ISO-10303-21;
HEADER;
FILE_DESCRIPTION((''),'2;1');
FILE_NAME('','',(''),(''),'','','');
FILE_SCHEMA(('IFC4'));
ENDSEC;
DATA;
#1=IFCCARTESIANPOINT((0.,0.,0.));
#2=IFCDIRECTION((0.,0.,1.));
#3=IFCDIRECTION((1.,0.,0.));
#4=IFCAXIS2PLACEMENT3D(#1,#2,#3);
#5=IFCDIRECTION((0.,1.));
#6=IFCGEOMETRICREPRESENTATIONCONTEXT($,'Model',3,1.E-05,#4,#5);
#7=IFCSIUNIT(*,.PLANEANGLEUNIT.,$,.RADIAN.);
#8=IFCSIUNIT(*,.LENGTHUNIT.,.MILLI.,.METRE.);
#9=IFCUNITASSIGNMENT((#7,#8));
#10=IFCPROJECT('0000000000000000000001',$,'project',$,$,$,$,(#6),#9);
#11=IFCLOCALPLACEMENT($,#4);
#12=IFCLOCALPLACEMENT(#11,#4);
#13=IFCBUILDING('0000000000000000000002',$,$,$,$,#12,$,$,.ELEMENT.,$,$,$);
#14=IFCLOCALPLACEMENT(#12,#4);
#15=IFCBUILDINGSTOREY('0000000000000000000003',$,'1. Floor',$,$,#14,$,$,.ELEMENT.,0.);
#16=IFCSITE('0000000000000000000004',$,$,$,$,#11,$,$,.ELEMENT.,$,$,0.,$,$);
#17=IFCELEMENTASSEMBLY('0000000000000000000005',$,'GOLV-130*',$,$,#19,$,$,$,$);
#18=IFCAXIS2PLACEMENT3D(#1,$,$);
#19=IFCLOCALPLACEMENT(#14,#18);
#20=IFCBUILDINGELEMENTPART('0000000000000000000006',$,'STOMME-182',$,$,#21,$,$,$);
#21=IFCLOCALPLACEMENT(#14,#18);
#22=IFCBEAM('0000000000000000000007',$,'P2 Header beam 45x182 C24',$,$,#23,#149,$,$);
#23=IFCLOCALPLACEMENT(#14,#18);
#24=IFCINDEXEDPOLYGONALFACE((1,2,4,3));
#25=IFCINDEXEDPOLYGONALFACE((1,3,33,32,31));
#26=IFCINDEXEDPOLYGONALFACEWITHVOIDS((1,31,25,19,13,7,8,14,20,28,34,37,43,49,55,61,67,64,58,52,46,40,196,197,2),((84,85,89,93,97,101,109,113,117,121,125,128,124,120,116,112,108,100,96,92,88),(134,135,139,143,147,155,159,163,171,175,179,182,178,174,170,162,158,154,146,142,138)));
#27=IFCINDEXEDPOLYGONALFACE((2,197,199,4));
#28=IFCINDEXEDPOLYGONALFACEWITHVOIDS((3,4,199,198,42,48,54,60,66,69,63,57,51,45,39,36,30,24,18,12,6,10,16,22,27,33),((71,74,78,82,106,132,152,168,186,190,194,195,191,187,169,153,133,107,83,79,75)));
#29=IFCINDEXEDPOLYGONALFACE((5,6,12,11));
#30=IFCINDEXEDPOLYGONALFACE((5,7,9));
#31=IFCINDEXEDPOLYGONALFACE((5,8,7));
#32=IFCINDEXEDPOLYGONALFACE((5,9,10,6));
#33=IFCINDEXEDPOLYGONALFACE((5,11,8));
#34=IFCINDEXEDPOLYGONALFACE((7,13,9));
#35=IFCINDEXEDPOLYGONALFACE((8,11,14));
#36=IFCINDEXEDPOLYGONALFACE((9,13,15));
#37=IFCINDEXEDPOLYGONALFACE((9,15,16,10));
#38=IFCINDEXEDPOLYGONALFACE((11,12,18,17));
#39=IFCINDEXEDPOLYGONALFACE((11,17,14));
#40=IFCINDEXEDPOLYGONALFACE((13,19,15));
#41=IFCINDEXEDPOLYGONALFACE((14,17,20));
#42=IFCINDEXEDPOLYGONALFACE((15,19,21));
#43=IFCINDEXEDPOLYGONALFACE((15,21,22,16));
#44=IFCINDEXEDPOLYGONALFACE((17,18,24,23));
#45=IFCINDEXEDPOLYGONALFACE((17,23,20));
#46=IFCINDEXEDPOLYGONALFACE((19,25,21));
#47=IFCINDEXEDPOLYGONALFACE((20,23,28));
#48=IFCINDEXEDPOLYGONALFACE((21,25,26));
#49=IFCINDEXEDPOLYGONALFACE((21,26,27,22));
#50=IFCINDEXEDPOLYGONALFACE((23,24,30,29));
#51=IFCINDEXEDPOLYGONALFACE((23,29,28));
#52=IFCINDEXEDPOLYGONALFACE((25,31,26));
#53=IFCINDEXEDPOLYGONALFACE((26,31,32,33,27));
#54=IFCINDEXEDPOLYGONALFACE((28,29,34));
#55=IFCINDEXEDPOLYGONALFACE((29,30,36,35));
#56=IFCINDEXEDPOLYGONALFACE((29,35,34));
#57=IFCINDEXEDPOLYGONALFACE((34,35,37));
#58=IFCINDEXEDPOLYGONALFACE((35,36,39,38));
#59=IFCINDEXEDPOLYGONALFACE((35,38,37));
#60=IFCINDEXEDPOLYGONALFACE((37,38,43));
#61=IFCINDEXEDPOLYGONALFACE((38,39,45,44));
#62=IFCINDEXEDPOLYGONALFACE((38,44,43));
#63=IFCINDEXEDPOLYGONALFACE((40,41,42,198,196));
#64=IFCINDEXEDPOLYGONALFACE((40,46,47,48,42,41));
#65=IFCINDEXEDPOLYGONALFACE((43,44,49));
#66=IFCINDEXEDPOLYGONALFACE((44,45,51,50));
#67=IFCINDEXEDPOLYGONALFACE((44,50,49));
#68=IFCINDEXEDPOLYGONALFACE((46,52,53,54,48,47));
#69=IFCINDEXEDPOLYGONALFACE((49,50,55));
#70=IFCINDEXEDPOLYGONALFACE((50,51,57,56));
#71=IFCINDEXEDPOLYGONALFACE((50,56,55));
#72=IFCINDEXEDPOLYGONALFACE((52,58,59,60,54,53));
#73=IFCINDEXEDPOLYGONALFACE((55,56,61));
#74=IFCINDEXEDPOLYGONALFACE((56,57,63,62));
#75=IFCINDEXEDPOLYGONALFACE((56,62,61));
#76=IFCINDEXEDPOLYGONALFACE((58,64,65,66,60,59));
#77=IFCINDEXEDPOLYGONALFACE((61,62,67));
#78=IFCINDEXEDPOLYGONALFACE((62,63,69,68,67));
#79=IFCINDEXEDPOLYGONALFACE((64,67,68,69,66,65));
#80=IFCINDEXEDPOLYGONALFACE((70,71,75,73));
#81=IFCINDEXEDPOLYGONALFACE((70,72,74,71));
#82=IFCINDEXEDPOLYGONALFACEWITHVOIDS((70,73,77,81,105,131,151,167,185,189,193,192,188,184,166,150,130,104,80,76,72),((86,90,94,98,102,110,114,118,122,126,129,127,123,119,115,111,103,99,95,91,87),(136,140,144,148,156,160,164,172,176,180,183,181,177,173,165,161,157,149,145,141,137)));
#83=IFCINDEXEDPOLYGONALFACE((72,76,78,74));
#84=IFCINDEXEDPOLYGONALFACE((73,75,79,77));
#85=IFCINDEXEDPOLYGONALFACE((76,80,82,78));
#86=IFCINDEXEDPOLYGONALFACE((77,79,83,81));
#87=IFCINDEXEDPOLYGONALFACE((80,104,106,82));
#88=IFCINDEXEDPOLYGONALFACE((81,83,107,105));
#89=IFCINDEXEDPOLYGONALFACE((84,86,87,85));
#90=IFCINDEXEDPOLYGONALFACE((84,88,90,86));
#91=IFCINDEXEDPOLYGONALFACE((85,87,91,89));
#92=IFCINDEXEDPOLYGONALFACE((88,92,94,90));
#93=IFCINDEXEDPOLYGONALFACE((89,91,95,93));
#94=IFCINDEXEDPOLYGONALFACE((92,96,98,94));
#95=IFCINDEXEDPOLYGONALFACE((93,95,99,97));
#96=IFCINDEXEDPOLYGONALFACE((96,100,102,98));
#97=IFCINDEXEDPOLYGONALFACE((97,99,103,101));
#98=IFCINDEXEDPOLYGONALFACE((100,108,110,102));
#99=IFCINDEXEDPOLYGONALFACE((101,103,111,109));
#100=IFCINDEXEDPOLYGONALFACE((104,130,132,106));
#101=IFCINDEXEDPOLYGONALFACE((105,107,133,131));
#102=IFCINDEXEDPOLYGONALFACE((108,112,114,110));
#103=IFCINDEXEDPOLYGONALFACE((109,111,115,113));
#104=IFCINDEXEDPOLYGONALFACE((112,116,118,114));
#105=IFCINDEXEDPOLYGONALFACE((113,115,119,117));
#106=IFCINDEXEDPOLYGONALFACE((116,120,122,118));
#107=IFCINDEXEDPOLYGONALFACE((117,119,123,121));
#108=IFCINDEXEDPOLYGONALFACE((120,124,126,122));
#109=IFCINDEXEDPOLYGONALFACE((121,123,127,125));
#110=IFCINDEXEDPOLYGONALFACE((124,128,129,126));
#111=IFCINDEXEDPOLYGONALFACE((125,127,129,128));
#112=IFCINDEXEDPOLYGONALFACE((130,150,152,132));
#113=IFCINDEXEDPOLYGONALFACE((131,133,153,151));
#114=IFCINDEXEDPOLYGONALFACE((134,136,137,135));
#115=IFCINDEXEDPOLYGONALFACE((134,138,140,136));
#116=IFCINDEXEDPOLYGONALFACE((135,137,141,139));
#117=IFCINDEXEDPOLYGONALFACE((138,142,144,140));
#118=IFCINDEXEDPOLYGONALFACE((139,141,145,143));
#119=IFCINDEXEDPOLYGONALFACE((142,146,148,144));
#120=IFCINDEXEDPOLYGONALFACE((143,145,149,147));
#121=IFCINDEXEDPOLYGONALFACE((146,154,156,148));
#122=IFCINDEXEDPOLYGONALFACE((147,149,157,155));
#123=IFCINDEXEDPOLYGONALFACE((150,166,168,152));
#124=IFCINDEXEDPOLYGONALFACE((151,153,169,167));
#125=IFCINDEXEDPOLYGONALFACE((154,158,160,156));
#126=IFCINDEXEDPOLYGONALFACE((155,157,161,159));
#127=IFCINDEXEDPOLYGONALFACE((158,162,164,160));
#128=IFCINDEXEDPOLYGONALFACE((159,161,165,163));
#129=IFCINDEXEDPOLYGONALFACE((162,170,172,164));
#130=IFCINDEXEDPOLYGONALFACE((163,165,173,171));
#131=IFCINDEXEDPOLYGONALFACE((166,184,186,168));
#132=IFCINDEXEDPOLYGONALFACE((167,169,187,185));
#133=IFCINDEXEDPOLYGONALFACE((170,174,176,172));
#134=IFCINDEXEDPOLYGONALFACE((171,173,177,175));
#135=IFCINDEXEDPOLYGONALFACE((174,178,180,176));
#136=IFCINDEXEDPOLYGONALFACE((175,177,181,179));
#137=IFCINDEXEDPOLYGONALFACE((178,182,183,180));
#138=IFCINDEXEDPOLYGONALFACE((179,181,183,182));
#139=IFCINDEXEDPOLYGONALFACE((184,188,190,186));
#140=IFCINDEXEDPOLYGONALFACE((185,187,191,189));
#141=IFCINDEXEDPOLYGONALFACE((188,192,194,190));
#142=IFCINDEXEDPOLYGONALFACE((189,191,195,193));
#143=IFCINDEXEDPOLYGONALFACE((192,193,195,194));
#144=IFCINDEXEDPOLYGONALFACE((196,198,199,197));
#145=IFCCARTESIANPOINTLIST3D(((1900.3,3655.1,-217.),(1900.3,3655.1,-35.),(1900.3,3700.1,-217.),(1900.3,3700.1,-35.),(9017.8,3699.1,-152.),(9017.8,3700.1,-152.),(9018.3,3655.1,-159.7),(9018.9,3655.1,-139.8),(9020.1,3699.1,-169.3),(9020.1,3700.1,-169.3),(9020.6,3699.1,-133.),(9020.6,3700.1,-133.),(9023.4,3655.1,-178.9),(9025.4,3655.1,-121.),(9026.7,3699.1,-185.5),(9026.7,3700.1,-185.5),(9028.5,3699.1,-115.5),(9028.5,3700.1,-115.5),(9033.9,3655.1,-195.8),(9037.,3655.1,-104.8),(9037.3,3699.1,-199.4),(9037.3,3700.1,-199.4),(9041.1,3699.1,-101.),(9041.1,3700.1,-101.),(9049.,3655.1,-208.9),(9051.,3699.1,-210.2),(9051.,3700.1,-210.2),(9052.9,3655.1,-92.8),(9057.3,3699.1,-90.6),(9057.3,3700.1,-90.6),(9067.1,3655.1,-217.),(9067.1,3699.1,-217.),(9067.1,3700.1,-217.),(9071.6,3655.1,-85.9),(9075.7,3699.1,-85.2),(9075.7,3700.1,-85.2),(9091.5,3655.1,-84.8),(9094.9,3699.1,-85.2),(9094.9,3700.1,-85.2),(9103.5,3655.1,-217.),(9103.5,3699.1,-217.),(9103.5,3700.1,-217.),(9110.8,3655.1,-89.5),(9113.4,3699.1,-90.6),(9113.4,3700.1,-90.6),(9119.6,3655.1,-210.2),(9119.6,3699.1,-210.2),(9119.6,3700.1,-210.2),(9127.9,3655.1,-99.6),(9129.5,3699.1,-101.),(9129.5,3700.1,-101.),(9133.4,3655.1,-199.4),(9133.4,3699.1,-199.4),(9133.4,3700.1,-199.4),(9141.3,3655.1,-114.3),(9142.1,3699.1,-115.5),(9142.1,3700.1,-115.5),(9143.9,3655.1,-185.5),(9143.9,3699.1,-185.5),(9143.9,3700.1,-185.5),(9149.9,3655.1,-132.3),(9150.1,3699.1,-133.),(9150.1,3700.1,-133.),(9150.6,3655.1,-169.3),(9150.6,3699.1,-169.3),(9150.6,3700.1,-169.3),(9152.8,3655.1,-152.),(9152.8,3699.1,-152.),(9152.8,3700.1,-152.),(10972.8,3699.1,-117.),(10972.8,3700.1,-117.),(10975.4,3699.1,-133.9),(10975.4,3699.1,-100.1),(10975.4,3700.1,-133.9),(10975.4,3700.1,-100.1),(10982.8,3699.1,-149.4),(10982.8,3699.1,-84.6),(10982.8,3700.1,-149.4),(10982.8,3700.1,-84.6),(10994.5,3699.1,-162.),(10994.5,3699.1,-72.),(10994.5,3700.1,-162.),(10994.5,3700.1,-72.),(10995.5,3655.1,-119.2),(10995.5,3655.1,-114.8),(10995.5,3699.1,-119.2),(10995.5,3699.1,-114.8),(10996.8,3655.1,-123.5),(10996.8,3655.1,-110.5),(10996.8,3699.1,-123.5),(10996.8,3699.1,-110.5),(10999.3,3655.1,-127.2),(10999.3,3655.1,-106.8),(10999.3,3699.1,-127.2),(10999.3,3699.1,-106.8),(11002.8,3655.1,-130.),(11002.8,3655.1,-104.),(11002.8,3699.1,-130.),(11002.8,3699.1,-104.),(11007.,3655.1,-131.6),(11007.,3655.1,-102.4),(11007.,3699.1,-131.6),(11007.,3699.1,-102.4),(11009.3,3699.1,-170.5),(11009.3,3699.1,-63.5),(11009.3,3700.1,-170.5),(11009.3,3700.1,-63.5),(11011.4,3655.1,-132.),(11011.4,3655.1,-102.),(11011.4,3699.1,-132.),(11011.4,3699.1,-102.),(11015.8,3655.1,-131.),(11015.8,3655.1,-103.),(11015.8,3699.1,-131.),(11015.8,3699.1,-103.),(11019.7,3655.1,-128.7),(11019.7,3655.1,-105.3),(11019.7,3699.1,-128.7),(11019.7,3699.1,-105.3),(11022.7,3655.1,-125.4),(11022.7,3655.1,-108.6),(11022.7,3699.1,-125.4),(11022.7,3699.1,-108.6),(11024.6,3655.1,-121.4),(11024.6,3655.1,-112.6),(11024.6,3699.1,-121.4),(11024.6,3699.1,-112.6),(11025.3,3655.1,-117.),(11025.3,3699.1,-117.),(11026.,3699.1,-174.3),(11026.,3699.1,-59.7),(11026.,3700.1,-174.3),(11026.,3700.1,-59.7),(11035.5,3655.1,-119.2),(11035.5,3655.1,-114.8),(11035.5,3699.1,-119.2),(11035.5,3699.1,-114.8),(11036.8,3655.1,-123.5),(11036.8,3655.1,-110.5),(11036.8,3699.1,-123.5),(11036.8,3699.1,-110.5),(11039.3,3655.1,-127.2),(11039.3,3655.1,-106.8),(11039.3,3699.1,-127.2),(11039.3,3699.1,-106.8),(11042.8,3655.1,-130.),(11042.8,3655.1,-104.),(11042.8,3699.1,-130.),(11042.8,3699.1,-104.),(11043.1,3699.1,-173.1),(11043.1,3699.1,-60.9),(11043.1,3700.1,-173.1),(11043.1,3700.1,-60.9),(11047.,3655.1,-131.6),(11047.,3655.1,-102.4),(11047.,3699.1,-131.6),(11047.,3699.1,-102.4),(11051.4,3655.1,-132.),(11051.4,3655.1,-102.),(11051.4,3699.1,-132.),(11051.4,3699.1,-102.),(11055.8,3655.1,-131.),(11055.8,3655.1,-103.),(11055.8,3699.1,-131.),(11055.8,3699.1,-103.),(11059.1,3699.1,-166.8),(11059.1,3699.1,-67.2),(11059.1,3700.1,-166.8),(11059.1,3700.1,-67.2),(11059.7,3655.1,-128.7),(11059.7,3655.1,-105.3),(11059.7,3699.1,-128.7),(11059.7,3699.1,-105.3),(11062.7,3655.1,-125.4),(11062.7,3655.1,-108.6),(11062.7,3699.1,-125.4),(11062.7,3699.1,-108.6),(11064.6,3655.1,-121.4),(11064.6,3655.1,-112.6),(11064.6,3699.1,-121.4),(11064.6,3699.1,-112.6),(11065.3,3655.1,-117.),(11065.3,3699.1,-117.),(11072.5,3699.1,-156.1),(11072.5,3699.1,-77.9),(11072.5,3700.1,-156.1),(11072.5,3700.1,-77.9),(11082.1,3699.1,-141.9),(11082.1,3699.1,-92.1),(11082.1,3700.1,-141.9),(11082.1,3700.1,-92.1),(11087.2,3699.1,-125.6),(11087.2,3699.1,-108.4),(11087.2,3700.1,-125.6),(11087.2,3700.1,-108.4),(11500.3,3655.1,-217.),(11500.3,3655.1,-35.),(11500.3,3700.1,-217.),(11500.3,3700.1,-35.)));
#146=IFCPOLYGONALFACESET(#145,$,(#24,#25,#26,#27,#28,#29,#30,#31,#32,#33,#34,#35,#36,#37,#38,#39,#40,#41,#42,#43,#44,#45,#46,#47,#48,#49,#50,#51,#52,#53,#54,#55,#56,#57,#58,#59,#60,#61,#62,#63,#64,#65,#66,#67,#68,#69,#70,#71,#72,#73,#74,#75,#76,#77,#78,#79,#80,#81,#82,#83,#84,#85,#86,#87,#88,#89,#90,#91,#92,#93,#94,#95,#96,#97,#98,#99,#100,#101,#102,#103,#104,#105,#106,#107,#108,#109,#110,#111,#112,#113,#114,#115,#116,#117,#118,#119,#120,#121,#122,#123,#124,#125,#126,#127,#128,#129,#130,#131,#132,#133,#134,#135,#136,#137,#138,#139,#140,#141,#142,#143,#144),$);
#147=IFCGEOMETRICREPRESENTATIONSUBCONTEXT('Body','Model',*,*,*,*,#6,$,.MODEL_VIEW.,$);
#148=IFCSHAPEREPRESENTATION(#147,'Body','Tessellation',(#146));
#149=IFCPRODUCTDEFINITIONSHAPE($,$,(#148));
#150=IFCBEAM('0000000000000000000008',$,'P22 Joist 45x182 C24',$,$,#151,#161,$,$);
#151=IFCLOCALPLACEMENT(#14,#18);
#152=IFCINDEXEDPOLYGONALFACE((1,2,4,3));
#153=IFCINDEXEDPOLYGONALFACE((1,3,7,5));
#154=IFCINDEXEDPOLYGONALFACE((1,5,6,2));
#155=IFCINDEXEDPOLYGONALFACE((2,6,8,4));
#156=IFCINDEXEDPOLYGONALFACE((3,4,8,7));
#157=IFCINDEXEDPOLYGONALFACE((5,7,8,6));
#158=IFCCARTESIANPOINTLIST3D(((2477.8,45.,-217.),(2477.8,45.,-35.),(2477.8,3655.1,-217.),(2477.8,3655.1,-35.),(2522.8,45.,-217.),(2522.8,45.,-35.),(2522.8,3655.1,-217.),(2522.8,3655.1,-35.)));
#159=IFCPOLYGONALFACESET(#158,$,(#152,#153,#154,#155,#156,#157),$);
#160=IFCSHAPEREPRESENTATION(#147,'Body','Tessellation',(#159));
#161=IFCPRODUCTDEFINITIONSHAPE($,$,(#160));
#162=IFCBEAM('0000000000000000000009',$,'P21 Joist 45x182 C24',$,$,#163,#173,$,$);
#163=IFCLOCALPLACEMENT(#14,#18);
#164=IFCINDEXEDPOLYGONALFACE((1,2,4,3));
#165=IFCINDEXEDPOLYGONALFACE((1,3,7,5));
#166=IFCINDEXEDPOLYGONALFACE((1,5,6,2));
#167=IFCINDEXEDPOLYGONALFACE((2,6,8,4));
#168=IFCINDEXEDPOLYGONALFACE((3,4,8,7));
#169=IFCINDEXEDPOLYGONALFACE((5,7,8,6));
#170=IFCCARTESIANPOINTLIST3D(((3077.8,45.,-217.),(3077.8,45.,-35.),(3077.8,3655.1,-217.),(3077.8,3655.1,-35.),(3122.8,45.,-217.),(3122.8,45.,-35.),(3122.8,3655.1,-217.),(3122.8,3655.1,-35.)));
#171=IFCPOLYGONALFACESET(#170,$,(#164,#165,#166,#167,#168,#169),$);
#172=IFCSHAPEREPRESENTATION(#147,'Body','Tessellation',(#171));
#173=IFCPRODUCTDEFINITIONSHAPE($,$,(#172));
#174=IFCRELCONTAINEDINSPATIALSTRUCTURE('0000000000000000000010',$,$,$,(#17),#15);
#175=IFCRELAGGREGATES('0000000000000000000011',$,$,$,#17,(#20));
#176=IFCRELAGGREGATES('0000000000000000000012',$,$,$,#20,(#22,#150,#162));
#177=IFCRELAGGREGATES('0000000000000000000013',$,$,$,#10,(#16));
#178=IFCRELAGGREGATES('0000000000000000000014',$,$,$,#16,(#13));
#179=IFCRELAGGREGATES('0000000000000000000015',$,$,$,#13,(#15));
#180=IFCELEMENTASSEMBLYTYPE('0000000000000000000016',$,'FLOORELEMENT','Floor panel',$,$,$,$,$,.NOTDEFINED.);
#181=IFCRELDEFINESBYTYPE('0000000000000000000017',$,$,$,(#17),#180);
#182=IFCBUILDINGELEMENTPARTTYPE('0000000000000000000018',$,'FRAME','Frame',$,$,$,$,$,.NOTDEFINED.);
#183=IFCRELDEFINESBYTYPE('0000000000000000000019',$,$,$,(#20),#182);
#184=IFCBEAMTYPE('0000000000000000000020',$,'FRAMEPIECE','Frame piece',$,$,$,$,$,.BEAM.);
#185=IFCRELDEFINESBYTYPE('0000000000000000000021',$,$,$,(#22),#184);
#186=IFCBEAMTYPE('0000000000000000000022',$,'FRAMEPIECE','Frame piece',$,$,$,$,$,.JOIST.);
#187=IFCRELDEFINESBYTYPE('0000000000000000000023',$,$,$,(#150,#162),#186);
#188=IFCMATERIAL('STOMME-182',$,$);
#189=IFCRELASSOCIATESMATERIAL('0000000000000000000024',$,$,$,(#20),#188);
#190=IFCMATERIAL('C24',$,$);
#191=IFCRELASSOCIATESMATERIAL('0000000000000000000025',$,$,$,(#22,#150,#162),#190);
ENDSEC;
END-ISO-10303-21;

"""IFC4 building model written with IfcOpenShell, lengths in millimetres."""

from ifc_helpers import new_model, si_unit, direction, frame, origin_with_axes, origin_2d_with_axis, place, context, subcontext, project, spatial, rectangle, circle, extrude, boolean, material, type_object, element, aggregate, save


model = new_model("IFC4")

# Units and contexts
model_context = context("Model", 3, precision=1e-05, world=origin_with_axes(), true_north=direction((0.0, 1.0)))
body_context = subcontext(model_context, "Body", "Model", "MODEL_VIEW")
ifc_project = project(units=[si_unit("PLANEANGLEUNIT", "RADIAN"), si_unit("LENGTHUNIT", "METRE", prefix="MILLI")], contexts=[model_context])

# Site, building, storey
site_placement = place(None, origin_with_axes())
site = spatial("IfcSite", under=ifc_project, at=site_placement, CompositionType="ELEMENT", RefElevation=0.0)
building_placement = place(site_placement, origin_with_axes())
building = spatial("IfcBuilding", under=site, at=building_placement, CompositionType="ELEMENT")
storey_placement = place(building_placement, origin_with_axes())
storey = spatial("IfcBuildingStorey", under=building, at=storey_placement, Name="1. Floor", CompositionType="ELEMENT", Elevation=0.0)

# Element assembly, building element part, beams
element_assembly_type = type_object("IfcElementAssemblyType", Name="FLOORELEMENT", Description="Floor panel", PredefinedType="NOTDEFINED")
assembly_placement = place(storey_placement, origin_with_axes())
assembly = element("IfcElementAssembly", 1, at=assembly_placement, inside=storey, type_object=element_assembly_type, Name="GOLV-130*")
ifc_material_1 = material(Name="STOMME-182")
building_element_part_type = type_object("IfcBuildingElementPartType", Name="FRAME", Description="Frame", PredefinedType="NOTDEFINED")
building_element_part_placement = place(storey_placement, origin_with_axes())
building_element_part = element("IfcBuildingElementPart", 2, at=building_element_part_placement, type_object=building_element_part_type, material=ifc_material_1, Name="STOMME-182")
aggregate(assembly, [building_element_part])
ifc_material_2 = material(Name="C24")
beam_type_1 = type_object("IfcBeamType", Name="FRAMEPIECE", Description="Frame piece", PredefinedType="BEAM")
beam_1_placement = place(storey_placement, frame((1900.3, 3677.6, -126.0), z_axis=(1.0, 0.0, 0.0), x_axis=(0.0, 1.0, 0.0)))
solid_1 = boolean("DIFFERENCE", boolean("DIFFERENCE", boolean("DIFFERENCE", boolean("DIFFERENCE", boolean("DIFFERENCE", boolean("DIFFERENCE", boolean("DIFFERENCE", boolean("DIFFERENCE", extrude(rectangle(XDim=45.0, YDim=182.0, at=origin_2d_with_axis()), origin_with_axes(), (0.0, 0.0, 1.0), 9600.0), extrude(circle(Radius=15.0, at=origin_2d_with_axis()), frame((23.0, 9.0, 9150.0), z_axis=(1.0, 0.0, 0.0), x_axis=(0.0, 0.0, 1.0)), (0.0, 0.0, -1.0), 46.0)), extrude(circle(Radius=67.5, at=origin_2d_with_axis()), frame((21.5, -26.0, 7185.0), z_axis=(-1.0, 0.0, 0.0), x_axis=(0.0, 0.0, -1.0)), (0.0, 0.0, -1.0), 1.5)), extrude(circle(Radius=67.5, at=origin_2d_with_axis()), frame((23.0, -26.0, 7185.0), z_axis=(1.0, 0.0, 0.0), x_axis=(0.0, 0.0, 1.0)), (0.0, 0.0, -1.0), 46.0)), extrude(circle(Radius=57.5, at=origin_2d_with_axis()), frame((21.5, 9.0, 9130.0), z_axis=(-1.0, 0.0, 0.0), x_axis=(0.0, 0.0, -1.0)), (0.0, 0.0, -1.0), 1.5)), extrude(circle(Radius=15.0, at=origin_2d_with_axis()), frame((23.0, 9.0, 9110.0), z_axis=(1.0, 0.0, 0.0), x_axis=(0.0, 0.0, 1.0)), (0.0, 0.0, -1.0), 46.0)), extrude(circle(Radius=15.0, at=origin_2d_with_axis()), frame((23.0, 9.0, 9110.0), z_axis=(1.0, 0.0, 0.0), x_axis=(0.0, 0.0, 1.0)), (0.0, 0.0, -1.0), 46.0)), extrude(circle(Radius=57.5, at=origin_2d_with_axis()), frame((21.5, 9.0, 9130.0), z_axis=(-1.0, 0.0, 0.0), x_axis=(0.0, 0.0, -1.0)), (0.0, 0.0, -1.0), 1.5)), extrude(circle(Radius=67.5, at=origin_2d_with_axis()), frame((21.5, -26.0, 7185.0), z_axis=(-1.0, 0.0, 0.0), x_axis=(0.0, 0.0, -1.0)), (0.0, 0.0, -1.0), 1.5))
solid_2 = boolean("DIFFERENCE", boolean("DIFFERENCE", boolean("DIFFERENCE", boolean("DIFFERENCE", boolean("DIFFERENCE", boolean("DIFFERENCE", boolean("DIFFERENCE", boolean("DIFFERENCE", solid_1, extrude(circle(Radius=67.5, at=origin_2d_with_axis()), frame((23.0, -26.0, 7185.0), z_axis=(1.0, 0.0, 0.0), x_axis=(0.0, 0.0, 1.0)), (0.0, 0.0, -1.0), 46.0)), extrude(circle(Radius=15.0, at=origin_2d_with_axis()), frame((23.0, 9.0, 9150.0), z_axis=(1.0, 0.0, 0.0), x_axis=(0.0, 0.0, 1.0)), (0.0, 0.0, -1.0), 46.0)), extrude(circle(Radius=67.5, at=origin_2d_with_axis()), frame((23.0, -26.0, 7185.0), z_axis=(1.0, 0.0, 0.0), x_axis=(0.0, 0.0, 1.0)), (0.0, 0.0, -1.0), 46.0)), extrude(circle(Radius=67.5, at=origin_2d_with_axis()), frame((21.5, -26.0, 7185.0), z_axis=(-1.0, 0.0, 0.0), x_axis=(0.0, 0.0, -1.0)), (0.0, 0.0, -1.0), 1.5)), extrude(circle(Radius=15.0, at=origin_2d_with_axis()), frame((23.0, 9.0, 9150.0), z_axis=(1.0, 0.0, 0.0), x_axis=(0.0, 0.0, 1.0)), (0.0, 0.0, -1.0), 46.0)), extrude(circle(Radius=15.0, at=origin_2d_with_axis()), frame((23.0, 9.0, 9110.0), z_axis=(1.0, 0.0, 0.0), x_axis=(0.0, 0.0, 1.0)), (0.0, 0.0, -1.0), 46.0)), extrude(circle(Radius=57.5, at=origin_2d_with_axis()), frame((21.5, 9.0, 9130.0), z_axis=(-1.0, 0.0, 0.0), x_axis=(0.0, 0.0, -1.0)), (0.0, 0.0, -1.0), 1.5)), extrude(circle(Radius=15.0, at=origin_2d_with_axis()), frame((23.0, 9.0, 9110.0), z_axis=(1.0, 0.0, 0.0), x_axis=(0.0, 0.0, 1.0)), (0.0, 0.0, -1.0), 46.0))
solid_3 = boolean("DIFFERENCE", boolean("DIFFERENCE", boolean("DIFFERENCE", boolean("DIFFERENCE", boolean("DIFFERENCE", boolean("DIFFERENCE", boolean("DIFFERENCE", boolean("DIFFERENCE", solid_2, extrude(circle(Radius=57.5, at=origin_2d_with_axis()), frame((21.5, 9.0, 9130.0), z_axis=(-1.0, 0.0, 0.0), x_axis=(0.0, 0.0, -1.0)), (0.0, 0.0, -1.0), 1.5)), extrude(circle(Radius=67.5, at=origin_2d_with_axis()), frame((21.5, -26.0, 7185.0), z_axis=(-1.0, 0.0, 0.0), x_axis=(0.0, 0.0, -1.0)), (0.0, 0.0, -1.0), 1.5)), extrude(circle(Radius=67.5, at=origin_2d_with_axis()), frame((23.0, -26.0, 7185.0), z_axis=(1.0, 0.0, 0.0), x_axis=(0.0, 0.0, 1.0)), (0.0, 0.0, -1.0), 46.0)), extrude(circle(Radius=15.0, at=origin_2d_with_axis()), frame((23.0, 9.0, 9150.0), z_axis=(1.0, 0.0, 0.0), x_axis=(0.0, 0.0, 1.0)), (0.0, 0.0, -1.0), 46.0)), extrude(circle(Radius=57.5, at=origin_2d_with_axis()), frame((21.5, 9.0, 9130.0), z_axis=(-1.0, 0.0, 0.0), x_axis=(0.0, 0.0, -1.0)), (0.0, 0.0, -1.0), 1.5)), extrude(circle(Radius=15.0, at=origin_2d_with_axis()), frame((23.0, 9.0, 9110.0), z_axis=(1.0, 0.0, 0.0), x_axis=(0.0, 0.0, 1.0)), (0.0, 0.0, -1.0), 46.0)), extrude(circle(Radius=67.5, at=origin_2d_with_axis()), frame((21.5, -26.0, 7185.0), z_axis=(-1.0, 0.0, 0.0), x_axis=(0.0, 0.0, -1.0)), (0.0, 0.0, -1.0), 1.5)), extrude(circle(Radius=67.5, at=origin_2d_with_axis()), frame((23.0, -26.0, 7185.0), z_axis=(1.0, 0.0, 0.0), x_axis=(0.0, 0.0, 1.0)), (0.0, 0.0, -1.0), 46.0))
beam_1 = element("IfcBeam", 3, at=beam_1_placement, type_object=beam_type_1, material=ifc_material_2, Name="P2 Header beam 45x182 C24", context=body_context, shape_type="CSG", body=[
    boolean("DIFFERENCE", solid_3, extrude(circle(Radius=15.0, at=origin_2d_with_axis()), frame((23.0, 9.0, 9150.0), z_axis=(1.0, 0.0, 0.0), x_axis=(0.0, 0.0, 1.0)), (0.0, 0.0, -1.0), 46.0)),
])
beam_type_2 = type_object("IfcBeamType", Name="FRAMEPIECE", Description="Frame piece", PredefinedType="JOIST")
beam_2_placement = place(storey_placement, frame((2500.3, 3655.1, -126.0), z_axis=(0.0, -1.0, 0.0), x_axis=(1.0, 0.0, 0.0)))
beam_2 = element("IfcBeam", 4, at=beam_2_placement, type_object=beam_type_2, material=ifc_material_2, Name="P22 Joist 45x182 C24", context=body_context, shape_type="SweptSolid", body=[
    extrude(rectangle(XDim=45.0, YDim=182.0, at=origin_2d_with_axis()), origin_with_axes(), (0.0, 0.0, 1.0), 3610.1),
])
beam_3_placement = place(storey_placement, frame((3100.3, 3655.1, -126.0), z_axis=(0.0, -1.0, 0.0), x_axis=(1.0, 0.0, 0.0)))
beam_3 = element("IfcBeam", 5, at=beam_3_placement, type_object=beam_type_2, material=ifc_material_2, Name="P21 Joist 45x182 C24", context=body_context, shape_type="SweptSolid", body=[
    extrude(rectangle(XDim=45.0, YDim=182.0, at=origin_2d_with_axis()), origin_with_axes(), (0.0, 0.0, 1.0), 3610.1),
])
aggregate(building_element_part, [beam_1, beam_2, beam_3])

save(model, "model.ifc")
